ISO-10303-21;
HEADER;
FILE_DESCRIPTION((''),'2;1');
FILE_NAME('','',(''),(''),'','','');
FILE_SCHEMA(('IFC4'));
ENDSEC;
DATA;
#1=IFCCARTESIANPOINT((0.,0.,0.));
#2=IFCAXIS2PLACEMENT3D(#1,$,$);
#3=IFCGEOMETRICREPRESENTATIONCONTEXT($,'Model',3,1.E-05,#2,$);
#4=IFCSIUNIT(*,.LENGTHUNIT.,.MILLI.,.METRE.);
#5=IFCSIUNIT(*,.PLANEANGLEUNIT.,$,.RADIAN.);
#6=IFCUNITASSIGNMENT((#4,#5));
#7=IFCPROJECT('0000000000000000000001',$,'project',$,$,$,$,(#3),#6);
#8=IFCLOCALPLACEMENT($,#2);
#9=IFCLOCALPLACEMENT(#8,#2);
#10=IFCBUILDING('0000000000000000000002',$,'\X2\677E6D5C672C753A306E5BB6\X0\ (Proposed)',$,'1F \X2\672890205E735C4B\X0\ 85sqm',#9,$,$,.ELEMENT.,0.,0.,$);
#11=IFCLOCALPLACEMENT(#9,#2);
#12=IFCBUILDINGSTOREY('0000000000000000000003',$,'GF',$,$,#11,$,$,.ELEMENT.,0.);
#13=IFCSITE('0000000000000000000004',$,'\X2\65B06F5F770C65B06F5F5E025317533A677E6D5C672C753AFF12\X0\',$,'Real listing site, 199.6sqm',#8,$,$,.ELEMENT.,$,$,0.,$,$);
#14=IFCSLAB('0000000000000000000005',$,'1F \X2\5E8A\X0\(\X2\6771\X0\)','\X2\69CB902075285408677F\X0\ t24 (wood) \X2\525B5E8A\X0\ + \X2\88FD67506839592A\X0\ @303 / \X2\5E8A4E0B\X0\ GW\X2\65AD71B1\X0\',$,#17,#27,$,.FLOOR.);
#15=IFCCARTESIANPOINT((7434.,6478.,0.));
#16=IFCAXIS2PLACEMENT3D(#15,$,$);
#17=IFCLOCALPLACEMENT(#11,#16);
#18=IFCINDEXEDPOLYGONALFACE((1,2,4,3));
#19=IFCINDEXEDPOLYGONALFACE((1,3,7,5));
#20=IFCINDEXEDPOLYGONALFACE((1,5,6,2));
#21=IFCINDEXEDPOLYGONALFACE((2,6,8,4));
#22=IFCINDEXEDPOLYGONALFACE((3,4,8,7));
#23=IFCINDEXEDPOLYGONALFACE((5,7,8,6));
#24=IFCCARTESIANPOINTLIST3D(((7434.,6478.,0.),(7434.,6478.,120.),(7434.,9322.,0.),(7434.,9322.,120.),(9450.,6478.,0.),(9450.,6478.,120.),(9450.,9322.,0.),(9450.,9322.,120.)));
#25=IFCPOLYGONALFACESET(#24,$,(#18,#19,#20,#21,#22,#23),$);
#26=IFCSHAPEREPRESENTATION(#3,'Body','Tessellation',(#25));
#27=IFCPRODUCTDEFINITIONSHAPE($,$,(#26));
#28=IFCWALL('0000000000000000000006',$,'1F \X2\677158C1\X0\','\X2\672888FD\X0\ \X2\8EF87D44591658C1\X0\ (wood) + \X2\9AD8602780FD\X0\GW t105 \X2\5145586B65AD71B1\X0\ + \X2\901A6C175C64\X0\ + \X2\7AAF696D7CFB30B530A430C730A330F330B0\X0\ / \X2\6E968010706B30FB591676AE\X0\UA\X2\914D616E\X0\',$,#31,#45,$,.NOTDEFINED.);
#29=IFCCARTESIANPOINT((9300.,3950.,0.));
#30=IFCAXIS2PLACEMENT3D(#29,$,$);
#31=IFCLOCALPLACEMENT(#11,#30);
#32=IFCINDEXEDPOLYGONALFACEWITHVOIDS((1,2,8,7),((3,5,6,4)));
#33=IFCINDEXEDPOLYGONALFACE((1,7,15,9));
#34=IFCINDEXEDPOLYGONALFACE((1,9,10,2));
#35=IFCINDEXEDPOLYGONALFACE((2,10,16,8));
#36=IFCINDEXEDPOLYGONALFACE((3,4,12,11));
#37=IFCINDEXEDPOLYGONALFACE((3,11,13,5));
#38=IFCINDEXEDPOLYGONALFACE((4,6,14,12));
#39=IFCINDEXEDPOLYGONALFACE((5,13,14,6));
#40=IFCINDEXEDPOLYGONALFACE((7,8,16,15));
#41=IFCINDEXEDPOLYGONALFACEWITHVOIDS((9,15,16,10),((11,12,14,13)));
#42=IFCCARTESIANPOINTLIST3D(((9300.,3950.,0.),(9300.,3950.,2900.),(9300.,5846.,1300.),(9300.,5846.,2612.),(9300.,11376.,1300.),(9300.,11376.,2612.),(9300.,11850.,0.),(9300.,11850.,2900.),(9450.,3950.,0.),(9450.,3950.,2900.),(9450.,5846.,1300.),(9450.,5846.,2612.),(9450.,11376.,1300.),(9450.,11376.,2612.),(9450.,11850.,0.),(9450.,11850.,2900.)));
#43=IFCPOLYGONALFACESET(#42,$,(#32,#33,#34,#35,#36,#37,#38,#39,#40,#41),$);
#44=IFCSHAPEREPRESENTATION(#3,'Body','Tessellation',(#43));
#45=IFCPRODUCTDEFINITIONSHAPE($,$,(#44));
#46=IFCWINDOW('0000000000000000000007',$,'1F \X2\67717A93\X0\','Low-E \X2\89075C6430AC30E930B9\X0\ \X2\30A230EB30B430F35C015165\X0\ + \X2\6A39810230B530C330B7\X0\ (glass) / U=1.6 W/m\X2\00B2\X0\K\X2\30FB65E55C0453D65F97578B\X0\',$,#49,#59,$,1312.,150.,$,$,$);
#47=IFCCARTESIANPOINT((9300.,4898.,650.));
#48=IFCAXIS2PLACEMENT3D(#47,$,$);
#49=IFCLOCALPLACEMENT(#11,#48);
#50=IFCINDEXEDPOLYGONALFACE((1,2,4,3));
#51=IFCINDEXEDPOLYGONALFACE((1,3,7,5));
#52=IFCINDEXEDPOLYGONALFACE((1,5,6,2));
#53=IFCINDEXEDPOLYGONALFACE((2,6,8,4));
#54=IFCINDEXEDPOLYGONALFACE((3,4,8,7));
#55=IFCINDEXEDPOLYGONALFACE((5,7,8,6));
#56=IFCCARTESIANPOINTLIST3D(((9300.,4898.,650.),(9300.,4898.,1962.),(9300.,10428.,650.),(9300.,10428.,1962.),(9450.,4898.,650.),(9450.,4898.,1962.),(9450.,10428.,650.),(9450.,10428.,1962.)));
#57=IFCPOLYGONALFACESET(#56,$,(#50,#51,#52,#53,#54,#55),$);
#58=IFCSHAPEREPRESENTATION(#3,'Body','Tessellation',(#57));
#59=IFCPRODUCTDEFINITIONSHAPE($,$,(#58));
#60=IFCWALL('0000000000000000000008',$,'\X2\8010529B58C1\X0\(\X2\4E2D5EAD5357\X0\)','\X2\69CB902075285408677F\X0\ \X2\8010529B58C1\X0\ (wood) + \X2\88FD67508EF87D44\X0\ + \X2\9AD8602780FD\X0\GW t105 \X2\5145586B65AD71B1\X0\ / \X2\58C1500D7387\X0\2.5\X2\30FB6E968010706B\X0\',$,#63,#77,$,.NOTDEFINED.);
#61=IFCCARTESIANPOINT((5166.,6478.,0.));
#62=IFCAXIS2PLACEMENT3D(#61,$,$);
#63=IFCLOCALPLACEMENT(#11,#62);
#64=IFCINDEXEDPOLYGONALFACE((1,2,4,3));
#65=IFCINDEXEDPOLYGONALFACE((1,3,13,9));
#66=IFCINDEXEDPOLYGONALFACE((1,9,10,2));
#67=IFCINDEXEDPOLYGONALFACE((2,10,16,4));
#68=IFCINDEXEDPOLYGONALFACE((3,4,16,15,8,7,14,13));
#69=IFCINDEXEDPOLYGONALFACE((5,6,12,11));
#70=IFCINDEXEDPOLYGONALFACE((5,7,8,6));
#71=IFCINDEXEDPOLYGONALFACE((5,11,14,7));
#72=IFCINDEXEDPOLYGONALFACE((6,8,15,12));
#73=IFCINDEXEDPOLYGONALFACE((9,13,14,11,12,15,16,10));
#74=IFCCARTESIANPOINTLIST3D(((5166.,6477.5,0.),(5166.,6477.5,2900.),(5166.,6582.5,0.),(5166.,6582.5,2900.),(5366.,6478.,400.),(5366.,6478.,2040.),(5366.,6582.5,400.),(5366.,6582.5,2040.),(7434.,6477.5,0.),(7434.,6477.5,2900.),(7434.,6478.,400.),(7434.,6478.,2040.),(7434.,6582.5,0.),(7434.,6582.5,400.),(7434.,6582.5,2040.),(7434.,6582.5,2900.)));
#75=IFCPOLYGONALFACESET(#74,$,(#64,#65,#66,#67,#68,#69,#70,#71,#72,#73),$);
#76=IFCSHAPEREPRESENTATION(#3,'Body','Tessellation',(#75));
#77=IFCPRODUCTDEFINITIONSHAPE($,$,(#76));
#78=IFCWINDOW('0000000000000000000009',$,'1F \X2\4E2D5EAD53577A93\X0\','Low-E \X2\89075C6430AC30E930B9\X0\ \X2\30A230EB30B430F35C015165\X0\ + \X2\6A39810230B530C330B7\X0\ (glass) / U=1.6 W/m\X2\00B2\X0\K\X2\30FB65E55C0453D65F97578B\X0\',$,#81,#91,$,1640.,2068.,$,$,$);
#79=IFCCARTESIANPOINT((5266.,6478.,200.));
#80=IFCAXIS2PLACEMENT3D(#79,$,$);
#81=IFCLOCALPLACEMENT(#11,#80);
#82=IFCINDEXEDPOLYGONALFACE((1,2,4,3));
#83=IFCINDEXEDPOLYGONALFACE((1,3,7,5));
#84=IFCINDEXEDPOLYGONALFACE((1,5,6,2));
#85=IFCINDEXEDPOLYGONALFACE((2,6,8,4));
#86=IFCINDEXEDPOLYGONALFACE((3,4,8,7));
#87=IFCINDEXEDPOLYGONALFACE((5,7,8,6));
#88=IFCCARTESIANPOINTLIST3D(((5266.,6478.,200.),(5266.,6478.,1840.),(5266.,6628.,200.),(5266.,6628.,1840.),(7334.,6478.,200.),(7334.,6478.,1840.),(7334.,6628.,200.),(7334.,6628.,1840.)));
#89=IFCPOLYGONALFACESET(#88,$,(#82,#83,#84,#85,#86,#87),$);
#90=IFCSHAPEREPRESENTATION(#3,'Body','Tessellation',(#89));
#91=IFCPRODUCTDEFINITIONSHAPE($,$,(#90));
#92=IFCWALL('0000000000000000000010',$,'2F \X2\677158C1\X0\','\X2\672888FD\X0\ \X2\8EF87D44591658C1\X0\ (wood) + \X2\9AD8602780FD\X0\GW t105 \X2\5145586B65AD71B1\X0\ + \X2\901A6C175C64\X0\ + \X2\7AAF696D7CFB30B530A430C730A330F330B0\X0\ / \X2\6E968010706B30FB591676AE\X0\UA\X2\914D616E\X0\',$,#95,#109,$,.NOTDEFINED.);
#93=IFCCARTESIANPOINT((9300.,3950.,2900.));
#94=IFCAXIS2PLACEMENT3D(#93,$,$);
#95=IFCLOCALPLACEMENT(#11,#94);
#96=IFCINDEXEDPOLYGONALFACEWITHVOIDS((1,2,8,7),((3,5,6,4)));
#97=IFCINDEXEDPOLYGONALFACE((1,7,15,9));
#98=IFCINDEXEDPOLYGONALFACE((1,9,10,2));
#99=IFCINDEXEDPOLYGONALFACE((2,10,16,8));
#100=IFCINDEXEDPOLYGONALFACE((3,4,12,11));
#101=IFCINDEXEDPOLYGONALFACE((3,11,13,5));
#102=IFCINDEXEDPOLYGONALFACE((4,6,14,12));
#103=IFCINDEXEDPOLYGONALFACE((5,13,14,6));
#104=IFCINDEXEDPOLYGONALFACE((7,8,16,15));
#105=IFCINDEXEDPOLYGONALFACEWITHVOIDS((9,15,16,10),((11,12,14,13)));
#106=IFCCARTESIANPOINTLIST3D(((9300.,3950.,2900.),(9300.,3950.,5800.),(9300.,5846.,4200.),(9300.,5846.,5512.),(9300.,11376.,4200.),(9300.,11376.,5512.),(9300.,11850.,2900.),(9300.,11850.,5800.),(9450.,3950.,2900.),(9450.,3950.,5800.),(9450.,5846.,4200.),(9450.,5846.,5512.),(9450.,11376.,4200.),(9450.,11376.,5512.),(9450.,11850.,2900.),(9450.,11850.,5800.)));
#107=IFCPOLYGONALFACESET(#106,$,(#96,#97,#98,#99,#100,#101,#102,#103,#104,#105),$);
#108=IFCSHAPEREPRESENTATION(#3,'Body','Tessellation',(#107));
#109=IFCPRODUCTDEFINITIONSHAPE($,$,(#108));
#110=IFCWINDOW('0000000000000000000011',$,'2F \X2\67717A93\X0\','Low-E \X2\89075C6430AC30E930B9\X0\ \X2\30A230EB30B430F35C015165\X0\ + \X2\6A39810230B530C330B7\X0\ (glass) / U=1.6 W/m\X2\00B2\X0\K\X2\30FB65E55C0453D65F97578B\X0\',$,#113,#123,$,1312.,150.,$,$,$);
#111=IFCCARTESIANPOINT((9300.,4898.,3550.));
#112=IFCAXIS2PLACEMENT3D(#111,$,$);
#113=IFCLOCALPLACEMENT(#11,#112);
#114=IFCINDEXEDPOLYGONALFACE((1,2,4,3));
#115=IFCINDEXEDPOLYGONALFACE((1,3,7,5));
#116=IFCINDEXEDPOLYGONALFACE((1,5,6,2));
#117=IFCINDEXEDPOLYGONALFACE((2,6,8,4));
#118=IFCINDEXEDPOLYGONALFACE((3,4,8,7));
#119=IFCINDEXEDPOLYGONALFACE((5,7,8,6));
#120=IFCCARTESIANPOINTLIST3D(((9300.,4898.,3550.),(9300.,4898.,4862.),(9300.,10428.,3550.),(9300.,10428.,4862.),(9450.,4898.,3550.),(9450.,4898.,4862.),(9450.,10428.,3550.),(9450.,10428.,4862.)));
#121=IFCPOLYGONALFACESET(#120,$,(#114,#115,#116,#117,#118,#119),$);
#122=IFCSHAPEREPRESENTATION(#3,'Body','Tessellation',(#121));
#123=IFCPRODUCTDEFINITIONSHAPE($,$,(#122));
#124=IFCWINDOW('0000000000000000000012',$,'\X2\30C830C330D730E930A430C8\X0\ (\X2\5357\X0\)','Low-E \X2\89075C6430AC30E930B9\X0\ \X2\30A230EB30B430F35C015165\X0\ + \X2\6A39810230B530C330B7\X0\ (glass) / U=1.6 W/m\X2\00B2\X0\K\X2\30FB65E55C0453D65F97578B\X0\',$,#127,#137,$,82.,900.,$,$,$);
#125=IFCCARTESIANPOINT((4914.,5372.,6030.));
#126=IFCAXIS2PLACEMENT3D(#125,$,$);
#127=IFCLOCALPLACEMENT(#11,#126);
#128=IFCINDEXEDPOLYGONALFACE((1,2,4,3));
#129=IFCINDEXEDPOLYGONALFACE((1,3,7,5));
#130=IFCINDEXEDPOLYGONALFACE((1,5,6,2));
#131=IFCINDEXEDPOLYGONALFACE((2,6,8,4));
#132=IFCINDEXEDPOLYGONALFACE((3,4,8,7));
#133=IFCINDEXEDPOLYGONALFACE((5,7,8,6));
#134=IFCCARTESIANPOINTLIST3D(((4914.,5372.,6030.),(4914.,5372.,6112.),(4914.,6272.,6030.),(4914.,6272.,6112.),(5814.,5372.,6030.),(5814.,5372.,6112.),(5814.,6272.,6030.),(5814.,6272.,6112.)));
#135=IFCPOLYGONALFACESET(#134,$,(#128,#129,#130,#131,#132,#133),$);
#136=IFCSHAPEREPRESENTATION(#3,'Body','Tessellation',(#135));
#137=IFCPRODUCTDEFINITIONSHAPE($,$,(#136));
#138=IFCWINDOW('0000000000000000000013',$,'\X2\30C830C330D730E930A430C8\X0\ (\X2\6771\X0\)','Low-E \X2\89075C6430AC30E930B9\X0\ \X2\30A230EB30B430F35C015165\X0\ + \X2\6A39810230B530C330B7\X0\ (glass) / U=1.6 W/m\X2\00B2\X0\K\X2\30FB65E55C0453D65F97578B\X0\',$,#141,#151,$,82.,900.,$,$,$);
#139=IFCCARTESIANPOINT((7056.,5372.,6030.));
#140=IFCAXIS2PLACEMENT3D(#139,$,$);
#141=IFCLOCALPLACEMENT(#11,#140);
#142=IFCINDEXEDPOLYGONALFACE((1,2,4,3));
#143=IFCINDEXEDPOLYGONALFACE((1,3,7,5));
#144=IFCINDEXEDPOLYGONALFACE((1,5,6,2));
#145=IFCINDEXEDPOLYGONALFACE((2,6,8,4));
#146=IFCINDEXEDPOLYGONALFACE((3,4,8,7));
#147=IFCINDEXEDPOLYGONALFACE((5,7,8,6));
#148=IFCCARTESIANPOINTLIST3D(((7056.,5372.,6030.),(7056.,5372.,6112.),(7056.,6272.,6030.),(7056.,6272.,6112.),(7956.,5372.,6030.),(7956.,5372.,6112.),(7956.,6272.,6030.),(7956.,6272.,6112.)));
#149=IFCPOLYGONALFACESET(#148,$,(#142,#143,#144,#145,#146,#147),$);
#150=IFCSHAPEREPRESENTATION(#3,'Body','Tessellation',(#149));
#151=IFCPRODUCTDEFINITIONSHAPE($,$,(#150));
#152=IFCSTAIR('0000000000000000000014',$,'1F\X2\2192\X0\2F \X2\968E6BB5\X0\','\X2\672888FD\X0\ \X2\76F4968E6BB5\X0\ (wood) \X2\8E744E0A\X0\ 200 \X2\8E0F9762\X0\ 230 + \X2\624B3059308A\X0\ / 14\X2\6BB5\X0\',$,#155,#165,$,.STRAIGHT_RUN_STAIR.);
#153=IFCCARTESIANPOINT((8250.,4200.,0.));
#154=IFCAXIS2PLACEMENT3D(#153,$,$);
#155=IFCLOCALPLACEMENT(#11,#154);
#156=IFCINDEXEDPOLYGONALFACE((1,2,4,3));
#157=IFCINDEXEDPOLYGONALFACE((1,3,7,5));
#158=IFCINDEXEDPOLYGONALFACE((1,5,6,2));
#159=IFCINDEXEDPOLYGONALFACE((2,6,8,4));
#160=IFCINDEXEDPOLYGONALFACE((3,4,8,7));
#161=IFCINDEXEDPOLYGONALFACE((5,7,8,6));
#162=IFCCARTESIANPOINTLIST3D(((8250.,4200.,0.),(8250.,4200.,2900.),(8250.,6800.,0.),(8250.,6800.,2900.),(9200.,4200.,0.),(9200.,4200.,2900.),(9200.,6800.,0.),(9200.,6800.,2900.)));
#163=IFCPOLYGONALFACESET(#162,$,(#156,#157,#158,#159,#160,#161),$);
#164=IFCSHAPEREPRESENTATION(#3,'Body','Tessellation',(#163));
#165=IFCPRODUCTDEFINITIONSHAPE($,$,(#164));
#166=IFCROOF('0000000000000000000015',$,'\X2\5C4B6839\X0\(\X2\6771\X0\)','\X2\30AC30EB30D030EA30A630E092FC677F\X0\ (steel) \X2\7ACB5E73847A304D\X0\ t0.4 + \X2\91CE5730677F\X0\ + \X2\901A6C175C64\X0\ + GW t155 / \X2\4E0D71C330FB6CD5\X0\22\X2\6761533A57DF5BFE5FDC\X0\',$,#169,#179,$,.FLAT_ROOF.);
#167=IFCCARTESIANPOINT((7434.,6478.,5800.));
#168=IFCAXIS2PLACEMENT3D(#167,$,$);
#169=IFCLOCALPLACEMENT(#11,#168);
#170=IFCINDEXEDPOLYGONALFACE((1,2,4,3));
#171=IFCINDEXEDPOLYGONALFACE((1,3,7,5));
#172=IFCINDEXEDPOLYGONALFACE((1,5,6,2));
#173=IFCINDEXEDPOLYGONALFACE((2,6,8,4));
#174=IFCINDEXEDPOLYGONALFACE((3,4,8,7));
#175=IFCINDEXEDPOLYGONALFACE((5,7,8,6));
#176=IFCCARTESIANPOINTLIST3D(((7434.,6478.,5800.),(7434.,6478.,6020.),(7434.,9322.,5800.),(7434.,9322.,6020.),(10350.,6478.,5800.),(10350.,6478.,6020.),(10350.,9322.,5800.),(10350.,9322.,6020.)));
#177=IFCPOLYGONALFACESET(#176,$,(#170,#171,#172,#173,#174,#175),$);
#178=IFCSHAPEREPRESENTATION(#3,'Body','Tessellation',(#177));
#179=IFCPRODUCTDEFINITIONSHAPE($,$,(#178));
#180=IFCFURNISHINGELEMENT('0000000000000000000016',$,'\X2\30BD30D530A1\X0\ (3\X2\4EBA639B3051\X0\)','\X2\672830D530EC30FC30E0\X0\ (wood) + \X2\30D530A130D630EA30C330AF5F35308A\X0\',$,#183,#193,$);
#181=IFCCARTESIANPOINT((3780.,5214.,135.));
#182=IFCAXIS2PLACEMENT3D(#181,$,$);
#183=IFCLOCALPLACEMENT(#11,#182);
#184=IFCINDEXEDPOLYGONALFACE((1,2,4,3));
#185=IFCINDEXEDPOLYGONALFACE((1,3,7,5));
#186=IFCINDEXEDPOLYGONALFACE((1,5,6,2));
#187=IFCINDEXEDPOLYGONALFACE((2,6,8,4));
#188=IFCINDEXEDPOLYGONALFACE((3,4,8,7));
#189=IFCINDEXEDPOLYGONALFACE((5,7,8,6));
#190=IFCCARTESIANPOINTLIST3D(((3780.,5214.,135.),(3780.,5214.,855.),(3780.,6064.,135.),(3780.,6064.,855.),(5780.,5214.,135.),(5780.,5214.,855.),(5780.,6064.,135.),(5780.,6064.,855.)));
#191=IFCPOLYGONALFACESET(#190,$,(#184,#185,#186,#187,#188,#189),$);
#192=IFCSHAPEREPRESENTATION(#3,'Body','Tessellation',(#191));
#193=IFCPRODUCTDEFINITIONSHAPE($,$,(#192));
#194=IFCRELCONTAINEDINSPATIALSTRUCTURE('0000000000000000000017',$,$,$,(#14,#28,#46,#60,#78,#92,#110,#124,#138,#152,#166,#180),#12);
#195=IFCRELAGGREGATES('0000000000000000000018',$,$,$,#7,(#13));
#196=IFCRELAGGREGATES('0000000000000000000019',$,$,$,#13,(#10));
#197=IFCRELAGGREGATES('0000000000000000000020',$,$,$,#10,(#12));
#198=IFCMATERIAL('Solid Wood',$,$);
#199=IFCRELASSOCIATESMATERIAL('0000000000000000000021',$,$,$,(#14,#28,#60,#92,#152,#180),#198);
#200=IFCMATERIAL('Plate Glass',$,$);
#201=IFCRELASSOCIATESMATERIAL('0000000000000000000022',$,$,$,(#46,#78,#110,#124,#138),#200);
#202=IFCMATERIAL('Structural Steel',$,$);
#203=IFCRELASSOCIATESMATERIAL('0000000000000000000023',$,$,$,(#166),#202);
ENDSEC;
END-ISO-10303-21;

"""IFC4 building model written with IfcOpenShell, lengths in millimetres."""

from ifc_helpers import new_model, si_unit, frame, frame_2d, origin, place, context, project, spatial, rectangle, extrude, material, element, fill, save


model = new_model("IFC4")

# Units and contexts
model_context = context("Model", 3, precision=1e-05, world=origin())
ifc_project = project(units=[si_unit("LENGTHUNIT", "METRE", prefix="MILLI"), si_unit("PLANEANGLEUNIT", "RADIAN")], contexts=[model_context])

# Site, building, storey
site_placement = place(None, origin())
site = spatial("IfcSite", under=ifc_project, at=site_placement, Name="新潟県新潟市北区松浜本町２", ObjectType="Real listing site, 199.6sqm", CompositionType="ELEMENT", RefElevation=0.0)
building_placement = place(site_placement, origin())
building = spatial("IfcBuilding", under=site, at=building_placement, Name="松浜本町の家 (Proposed)", ObjectType="1F 木造平屋 85sqm", CompositionType="ELEMENT", ElevationOfRefHeight=0.0, ElevationOfTerrain=0.0)
storey_placement = place(building_placement, origin())
storey = spatial("IfcBuildingStorey", under=building, at=storey_placement, Name="GF", CompositionType="ELEMENT", Elevation=0.0)

# Slab
ifc_material_1 = material(Name="Solid Wood")
slab_placement = place(storey_placement, frame((7434.0, 6478.0, 0.0)))
element("IfcSlab", 1, at=slab_placement, inside=storey, material=ifc_material_1, Name="1F 床(東)", Description="構造用合板 t24 (wood) 剛床 + 製材根太 @303 / 床下 GW断熱", PredefinedType="FLOOR", context=model_context, shape_type="SweptSolid", body=[
    extrude(rectangle(XDim=2016.0, YDim=2844.0, at=frame_2d((1008.0, 1422.0))), frame((7434.0, 6478.0, 0.0)), (0.0, 0.0, 1.0), 120.0),
])

# Walls, openings, windows
wall_1_placement = place(storey_placement, frame((9300.0, 3950.0, 0.0)))
wall_1 = element("IfcWall", 2, at=wall_1_placement, inside=storey, material=ifc_material_1, Name="1F 東壁", Description="木製 軸組外壁 (wood) + 高性能GW t105 充填断熱 + 通気層 + 窯業系サイディング / 準耐火・外皮UA配慮", PredefinedType="NOTDEFINED", context=model_context, shape_type="SweptSolid", body=[
    extrude(rectangle(XDim=150.0, YDim=7900.0, at=frame_2d((75.0, 3950.0))), frame((9300.0, 3950.0, 0.0)), (0.0, 0.0, 1.0), 2900.0),
])
opening_1_placement = place(storey_placement, frame((9300.0, 4898.0, 650.0)))
opening_1 = element("IfcOpeningElement", 3, at=opening_1_placement, cuts=wall_1, PredefinedType="NOTDEFINED", context=model_context, shape_type="SweptSolid", body=[
    extrude(rectangle(XDim=150.0, YDim=5530.0, at=frame_2d((75.0, 2765.0))), frame((9300.0, 4898.0, 650.0)), (0.0, 0.0, 1.0), 1312.0),
])
ifc_material_2 = material(Name="Plate Glass")
window_1_placement = place(storey_placement, frame((9300.0, 4898.0, 650.0)))
window_1 = element("IfcWindow", 4, at=window_1_placement, inside=storey, material=ifc_material_2, Name="1F 東窓", Description="Low-E 複層ガラス アルゴン封入 + 樹脂サッシ (glass) / U=1.6 W/m²K・日射取得型", OverallHeight=1312.0, OverallWidth=150.0, context=model_context, shape_type="SweptSolid", body=[
    extrude(rectangle(XDim=150.0, YDim=5530.0, at=frame_2d((75.0, 2765.0))), frame((9300.0, 4898.0, 650.0)), (0.0, 0.0, 1.0), 1312.0),
])
fill(opening_1, window_1)
wall_2_placement = place(storey_placement, frame((5166.0, 6478.0, 0.0)))
wall_2 = element("IfcWall", 5, at=wall_2_placement, inside=storey, material=ifc_material_1, Name="耐力壁(中庭南)", Description="構造用合板 耐力壁 (wood) + 製材軸組 + 高性能GW t105 充填断熱 / 壁倍率2.5・準耐火", PredefinedType="NOTDEFINED", context=model_context, shape_type="SweptSolid", body=[
    extrude(rectangle(XDim=2268.0, YDim=105.0, at=frame_2d((1134.0, 52.0))), frame((5166.0, 6478.0, 0.0)), (0.0, 0.0, 1.0), 2900.0),
])
opening_2_placement = place(storey_placement, frame((5266.0, 6478.0, 200.0)))
opening_2 = element("IfcOpeningElement", 6, at=opening_2_placement, cuts=wall_2, PredefinedType="NOTDEFINED", context=model_context, shape_type="SweptSolid", body=[
    extrude(rectangle(XDim=2068.0, YDim=150.0, at=frame_2d((1034.0, 75.0))), frame((5266.0, 6478.0, 200.0)), (0.0, 0.0, 1.0), 1640.0),
])
window_2_placement = place(storey_placement, frame((5266.0, 6478.0, 200.0)))
window_2 = element("IfcWindow", 7, at=window_2_placement, inside=storey, material=ifc_material_2, Name="1F 中庭南窓", Description="Low-E 複層ガラス アルゴン封入 + 樹脂サッシ (glass) / U=1.6 W/m²K・日射取得型", OverallHeight=1640.0, OverallWidth=2068.0, context=model_context, shape_type="SweptSolid", body=[
    extrude(rectangle(XDim=2068.0, YDim=150.0, at=frame_2d((1034.0, 75.0))), frame((5266.0, 6478.0, 200.0)), (0.0, 0.0, 1.0), 1640.0),
])
fill(opening_2, window_2)

# Wall, opening, window
wall_3_placement = place(storey_placement, frame((9300.0, 3950.0, 2900.0)))
wall_3 = element("IfcWall", 8, at=wall_3_placement, inside=storey, material=ifc_material_1, Name="2F 東壁", Description="木製 軸組外壁 (wood) + 高性能GW t105 充填断熱 + 通気層 + 窯業系サイディング / 準耐火・外皮UA配慮", PredefinedType="NOTDEFINED", context=model_context, shape_type="SweptSolid", body=[
    extrude(rectangle(XDim=150.0, YDim=7900.0, at=frame_2d((75.0, 3950.0))), frame((9300.0, 3950.0, 2900.0)), (0.0, 0.0, 1.0), 2900.0),
])
opening_3_placement = place(storey_placement, frame((9300.0, 4898.0, 3550.0)))
opening_3 = element("IfcOpeningElement", 9, at=opening_3_placement, cuts=wall_3, PredefinedType="NOTDEFINED", context=model_context, shape_type="SweptSolid", body=[
    extrude(rectangle(XDim=150.0, YDim=5530.0, at=frame_2d((75.0, 2765.0))), frame((9300.0, 4898.0, 3550.0)), (0.0, 0.0, 1.0), 1312.0),
])
window_3_placement = place(storey_placement, frame((9300.0, 4898.0, 3550.0)))
window_3 = element("IfcWindow", 10, at=window_3_placement, inside=storey, material=ifc_material_2, Name="2F 東窓", Description="Low-E 複層ガラス アルゴン封入 + 樹脂サッシ (glass) / U=1.6 W/m²K・日射取得型", OverallHeight=1312.0, OverallWidth=150.0, context=model_context, shape_type="SweptSolid", body=[
    extrude(rectangle(XDim=150.0, YDim=5530.0, at=frame_2d((75.0, 2765.0))), frame((9300.0, 4898.0, 3550.0)), (0.0, 0.0, 1.0), 1312.0),
])
fill(opening_3, window_3)

# Windows
window_4_placement = place(storey_placement, frame((4914.0, 5372.0, 6030.0)))
element("IfcWindow", 11, at=window_4_placement, inside=storey, material=ifc_material_2, Name="トップライト (南)", Description="Low-E 複層ガラス アルゴン封入 + 樹脂サッシ (glass) / U=1.6 W/m²K・日射取得型", OverallHeight=82.0, OverallWidth=900.0, context=model_context, shape_type="SweptSolid", body=[
    extrude(rectangle(XDim=900.0, YDim=900.0, at=frame_2d((450.0, 450.0))), frame((4914.0, 5372.0, 6030.0)), (0.0, 0.0, 1.0), 82.0),
])
window_5_placement = place(storey_placement, frame((7056.0, 5372.0, 6030.0)))
element("IfcWindow", 12, at=window_5_placement, inside=storey, material=ifc_material_2, Name="トップライト (東)", Description="Low-E 複層ガラス アルゴン封入 + 樹脂サッシ (glass) / U=1.6 W/m²K・日射取得型", OverallHeight=82.0, OverallWidth=900.0, context=model_context, shape_type="SweptSolid", body=[
    extrude(rectangle(XDim=900.0, YDim=900.0, at=frame_2d((450.0, 450.0))), frame((7056.0, 5372.0, 6030.0)), (0.0, 0.0, 1.0), 82.0),
])

# Stair
stair_placement = place(storey_placement, frame((8250.0, 4200.0, 0.0)))
element("IfcStair", 13, at=stair_placement, inside=storey, material=ifc_material_1, Name="1F→2F 階段", Description="木製 直階段 (wood) 蹴上 200 踏面 230 + 手すり / 14段", PredefinedType="STRAIGHT_RUN_STAIR", context=model_context, shape_type="SweptSolid", body=[
    extrude(rectangle(XDim=950.0, YDim=2600.0, at=frame_2d((475.0, 1300.0))), frame((8250.0, 4200.0, 0.0)), (0.0, 0.0, 1.0), 2900.0),
])

# Roof
ifc_material_3 = material(Name="Structural Steel")
roof_placement = place(storey_placement, frame((7434.0, 6478.0, 5800.0)))
element("IfcRoof", 14, at=roof_placement, inside=storey, material=ifc_material_3, Name="屋根(東)", Description="ガルバリウム鋼板 (steel) 立平葺き t0.4 + 野地板 + 通気層 + GW t155 / 不燃・法22条区域対応", PredefinedType="FLAT_ROOF", context=model_context, shape_type="SweptSolid", body=[
    extrude(rectangle(XDim=2916.0, YDim=2844.0, at=frame_2d((1458.0, 1422.0))), frame((7434.0, 6478.0, 5800.0)), (0.0, 0.0, 1.0), 220.0),
])

# Furnishing element
furnishing_1_placement = place(storey_placement, frame((3780.0, 5214.0, 135.0)))
element("IfcFurnishingElement", 15, at=furnishing_1_placement, inside=storey, material=ifc_material_1, Name="ソファ (3人掛け)", Description="木フレーム (wood) + ファブリック張り", context=model_context, shape_type="SweptSolid", body=[
    extrude(rectangle(XDim=2000.0, YDim=850.0, at=frame_2d((1000.0, 425.0))), frame((3780.0, 5214.0, 135.0)), (0.0, 0.0, 1.0), 720.0),
])

save(model, "model.ifc")
